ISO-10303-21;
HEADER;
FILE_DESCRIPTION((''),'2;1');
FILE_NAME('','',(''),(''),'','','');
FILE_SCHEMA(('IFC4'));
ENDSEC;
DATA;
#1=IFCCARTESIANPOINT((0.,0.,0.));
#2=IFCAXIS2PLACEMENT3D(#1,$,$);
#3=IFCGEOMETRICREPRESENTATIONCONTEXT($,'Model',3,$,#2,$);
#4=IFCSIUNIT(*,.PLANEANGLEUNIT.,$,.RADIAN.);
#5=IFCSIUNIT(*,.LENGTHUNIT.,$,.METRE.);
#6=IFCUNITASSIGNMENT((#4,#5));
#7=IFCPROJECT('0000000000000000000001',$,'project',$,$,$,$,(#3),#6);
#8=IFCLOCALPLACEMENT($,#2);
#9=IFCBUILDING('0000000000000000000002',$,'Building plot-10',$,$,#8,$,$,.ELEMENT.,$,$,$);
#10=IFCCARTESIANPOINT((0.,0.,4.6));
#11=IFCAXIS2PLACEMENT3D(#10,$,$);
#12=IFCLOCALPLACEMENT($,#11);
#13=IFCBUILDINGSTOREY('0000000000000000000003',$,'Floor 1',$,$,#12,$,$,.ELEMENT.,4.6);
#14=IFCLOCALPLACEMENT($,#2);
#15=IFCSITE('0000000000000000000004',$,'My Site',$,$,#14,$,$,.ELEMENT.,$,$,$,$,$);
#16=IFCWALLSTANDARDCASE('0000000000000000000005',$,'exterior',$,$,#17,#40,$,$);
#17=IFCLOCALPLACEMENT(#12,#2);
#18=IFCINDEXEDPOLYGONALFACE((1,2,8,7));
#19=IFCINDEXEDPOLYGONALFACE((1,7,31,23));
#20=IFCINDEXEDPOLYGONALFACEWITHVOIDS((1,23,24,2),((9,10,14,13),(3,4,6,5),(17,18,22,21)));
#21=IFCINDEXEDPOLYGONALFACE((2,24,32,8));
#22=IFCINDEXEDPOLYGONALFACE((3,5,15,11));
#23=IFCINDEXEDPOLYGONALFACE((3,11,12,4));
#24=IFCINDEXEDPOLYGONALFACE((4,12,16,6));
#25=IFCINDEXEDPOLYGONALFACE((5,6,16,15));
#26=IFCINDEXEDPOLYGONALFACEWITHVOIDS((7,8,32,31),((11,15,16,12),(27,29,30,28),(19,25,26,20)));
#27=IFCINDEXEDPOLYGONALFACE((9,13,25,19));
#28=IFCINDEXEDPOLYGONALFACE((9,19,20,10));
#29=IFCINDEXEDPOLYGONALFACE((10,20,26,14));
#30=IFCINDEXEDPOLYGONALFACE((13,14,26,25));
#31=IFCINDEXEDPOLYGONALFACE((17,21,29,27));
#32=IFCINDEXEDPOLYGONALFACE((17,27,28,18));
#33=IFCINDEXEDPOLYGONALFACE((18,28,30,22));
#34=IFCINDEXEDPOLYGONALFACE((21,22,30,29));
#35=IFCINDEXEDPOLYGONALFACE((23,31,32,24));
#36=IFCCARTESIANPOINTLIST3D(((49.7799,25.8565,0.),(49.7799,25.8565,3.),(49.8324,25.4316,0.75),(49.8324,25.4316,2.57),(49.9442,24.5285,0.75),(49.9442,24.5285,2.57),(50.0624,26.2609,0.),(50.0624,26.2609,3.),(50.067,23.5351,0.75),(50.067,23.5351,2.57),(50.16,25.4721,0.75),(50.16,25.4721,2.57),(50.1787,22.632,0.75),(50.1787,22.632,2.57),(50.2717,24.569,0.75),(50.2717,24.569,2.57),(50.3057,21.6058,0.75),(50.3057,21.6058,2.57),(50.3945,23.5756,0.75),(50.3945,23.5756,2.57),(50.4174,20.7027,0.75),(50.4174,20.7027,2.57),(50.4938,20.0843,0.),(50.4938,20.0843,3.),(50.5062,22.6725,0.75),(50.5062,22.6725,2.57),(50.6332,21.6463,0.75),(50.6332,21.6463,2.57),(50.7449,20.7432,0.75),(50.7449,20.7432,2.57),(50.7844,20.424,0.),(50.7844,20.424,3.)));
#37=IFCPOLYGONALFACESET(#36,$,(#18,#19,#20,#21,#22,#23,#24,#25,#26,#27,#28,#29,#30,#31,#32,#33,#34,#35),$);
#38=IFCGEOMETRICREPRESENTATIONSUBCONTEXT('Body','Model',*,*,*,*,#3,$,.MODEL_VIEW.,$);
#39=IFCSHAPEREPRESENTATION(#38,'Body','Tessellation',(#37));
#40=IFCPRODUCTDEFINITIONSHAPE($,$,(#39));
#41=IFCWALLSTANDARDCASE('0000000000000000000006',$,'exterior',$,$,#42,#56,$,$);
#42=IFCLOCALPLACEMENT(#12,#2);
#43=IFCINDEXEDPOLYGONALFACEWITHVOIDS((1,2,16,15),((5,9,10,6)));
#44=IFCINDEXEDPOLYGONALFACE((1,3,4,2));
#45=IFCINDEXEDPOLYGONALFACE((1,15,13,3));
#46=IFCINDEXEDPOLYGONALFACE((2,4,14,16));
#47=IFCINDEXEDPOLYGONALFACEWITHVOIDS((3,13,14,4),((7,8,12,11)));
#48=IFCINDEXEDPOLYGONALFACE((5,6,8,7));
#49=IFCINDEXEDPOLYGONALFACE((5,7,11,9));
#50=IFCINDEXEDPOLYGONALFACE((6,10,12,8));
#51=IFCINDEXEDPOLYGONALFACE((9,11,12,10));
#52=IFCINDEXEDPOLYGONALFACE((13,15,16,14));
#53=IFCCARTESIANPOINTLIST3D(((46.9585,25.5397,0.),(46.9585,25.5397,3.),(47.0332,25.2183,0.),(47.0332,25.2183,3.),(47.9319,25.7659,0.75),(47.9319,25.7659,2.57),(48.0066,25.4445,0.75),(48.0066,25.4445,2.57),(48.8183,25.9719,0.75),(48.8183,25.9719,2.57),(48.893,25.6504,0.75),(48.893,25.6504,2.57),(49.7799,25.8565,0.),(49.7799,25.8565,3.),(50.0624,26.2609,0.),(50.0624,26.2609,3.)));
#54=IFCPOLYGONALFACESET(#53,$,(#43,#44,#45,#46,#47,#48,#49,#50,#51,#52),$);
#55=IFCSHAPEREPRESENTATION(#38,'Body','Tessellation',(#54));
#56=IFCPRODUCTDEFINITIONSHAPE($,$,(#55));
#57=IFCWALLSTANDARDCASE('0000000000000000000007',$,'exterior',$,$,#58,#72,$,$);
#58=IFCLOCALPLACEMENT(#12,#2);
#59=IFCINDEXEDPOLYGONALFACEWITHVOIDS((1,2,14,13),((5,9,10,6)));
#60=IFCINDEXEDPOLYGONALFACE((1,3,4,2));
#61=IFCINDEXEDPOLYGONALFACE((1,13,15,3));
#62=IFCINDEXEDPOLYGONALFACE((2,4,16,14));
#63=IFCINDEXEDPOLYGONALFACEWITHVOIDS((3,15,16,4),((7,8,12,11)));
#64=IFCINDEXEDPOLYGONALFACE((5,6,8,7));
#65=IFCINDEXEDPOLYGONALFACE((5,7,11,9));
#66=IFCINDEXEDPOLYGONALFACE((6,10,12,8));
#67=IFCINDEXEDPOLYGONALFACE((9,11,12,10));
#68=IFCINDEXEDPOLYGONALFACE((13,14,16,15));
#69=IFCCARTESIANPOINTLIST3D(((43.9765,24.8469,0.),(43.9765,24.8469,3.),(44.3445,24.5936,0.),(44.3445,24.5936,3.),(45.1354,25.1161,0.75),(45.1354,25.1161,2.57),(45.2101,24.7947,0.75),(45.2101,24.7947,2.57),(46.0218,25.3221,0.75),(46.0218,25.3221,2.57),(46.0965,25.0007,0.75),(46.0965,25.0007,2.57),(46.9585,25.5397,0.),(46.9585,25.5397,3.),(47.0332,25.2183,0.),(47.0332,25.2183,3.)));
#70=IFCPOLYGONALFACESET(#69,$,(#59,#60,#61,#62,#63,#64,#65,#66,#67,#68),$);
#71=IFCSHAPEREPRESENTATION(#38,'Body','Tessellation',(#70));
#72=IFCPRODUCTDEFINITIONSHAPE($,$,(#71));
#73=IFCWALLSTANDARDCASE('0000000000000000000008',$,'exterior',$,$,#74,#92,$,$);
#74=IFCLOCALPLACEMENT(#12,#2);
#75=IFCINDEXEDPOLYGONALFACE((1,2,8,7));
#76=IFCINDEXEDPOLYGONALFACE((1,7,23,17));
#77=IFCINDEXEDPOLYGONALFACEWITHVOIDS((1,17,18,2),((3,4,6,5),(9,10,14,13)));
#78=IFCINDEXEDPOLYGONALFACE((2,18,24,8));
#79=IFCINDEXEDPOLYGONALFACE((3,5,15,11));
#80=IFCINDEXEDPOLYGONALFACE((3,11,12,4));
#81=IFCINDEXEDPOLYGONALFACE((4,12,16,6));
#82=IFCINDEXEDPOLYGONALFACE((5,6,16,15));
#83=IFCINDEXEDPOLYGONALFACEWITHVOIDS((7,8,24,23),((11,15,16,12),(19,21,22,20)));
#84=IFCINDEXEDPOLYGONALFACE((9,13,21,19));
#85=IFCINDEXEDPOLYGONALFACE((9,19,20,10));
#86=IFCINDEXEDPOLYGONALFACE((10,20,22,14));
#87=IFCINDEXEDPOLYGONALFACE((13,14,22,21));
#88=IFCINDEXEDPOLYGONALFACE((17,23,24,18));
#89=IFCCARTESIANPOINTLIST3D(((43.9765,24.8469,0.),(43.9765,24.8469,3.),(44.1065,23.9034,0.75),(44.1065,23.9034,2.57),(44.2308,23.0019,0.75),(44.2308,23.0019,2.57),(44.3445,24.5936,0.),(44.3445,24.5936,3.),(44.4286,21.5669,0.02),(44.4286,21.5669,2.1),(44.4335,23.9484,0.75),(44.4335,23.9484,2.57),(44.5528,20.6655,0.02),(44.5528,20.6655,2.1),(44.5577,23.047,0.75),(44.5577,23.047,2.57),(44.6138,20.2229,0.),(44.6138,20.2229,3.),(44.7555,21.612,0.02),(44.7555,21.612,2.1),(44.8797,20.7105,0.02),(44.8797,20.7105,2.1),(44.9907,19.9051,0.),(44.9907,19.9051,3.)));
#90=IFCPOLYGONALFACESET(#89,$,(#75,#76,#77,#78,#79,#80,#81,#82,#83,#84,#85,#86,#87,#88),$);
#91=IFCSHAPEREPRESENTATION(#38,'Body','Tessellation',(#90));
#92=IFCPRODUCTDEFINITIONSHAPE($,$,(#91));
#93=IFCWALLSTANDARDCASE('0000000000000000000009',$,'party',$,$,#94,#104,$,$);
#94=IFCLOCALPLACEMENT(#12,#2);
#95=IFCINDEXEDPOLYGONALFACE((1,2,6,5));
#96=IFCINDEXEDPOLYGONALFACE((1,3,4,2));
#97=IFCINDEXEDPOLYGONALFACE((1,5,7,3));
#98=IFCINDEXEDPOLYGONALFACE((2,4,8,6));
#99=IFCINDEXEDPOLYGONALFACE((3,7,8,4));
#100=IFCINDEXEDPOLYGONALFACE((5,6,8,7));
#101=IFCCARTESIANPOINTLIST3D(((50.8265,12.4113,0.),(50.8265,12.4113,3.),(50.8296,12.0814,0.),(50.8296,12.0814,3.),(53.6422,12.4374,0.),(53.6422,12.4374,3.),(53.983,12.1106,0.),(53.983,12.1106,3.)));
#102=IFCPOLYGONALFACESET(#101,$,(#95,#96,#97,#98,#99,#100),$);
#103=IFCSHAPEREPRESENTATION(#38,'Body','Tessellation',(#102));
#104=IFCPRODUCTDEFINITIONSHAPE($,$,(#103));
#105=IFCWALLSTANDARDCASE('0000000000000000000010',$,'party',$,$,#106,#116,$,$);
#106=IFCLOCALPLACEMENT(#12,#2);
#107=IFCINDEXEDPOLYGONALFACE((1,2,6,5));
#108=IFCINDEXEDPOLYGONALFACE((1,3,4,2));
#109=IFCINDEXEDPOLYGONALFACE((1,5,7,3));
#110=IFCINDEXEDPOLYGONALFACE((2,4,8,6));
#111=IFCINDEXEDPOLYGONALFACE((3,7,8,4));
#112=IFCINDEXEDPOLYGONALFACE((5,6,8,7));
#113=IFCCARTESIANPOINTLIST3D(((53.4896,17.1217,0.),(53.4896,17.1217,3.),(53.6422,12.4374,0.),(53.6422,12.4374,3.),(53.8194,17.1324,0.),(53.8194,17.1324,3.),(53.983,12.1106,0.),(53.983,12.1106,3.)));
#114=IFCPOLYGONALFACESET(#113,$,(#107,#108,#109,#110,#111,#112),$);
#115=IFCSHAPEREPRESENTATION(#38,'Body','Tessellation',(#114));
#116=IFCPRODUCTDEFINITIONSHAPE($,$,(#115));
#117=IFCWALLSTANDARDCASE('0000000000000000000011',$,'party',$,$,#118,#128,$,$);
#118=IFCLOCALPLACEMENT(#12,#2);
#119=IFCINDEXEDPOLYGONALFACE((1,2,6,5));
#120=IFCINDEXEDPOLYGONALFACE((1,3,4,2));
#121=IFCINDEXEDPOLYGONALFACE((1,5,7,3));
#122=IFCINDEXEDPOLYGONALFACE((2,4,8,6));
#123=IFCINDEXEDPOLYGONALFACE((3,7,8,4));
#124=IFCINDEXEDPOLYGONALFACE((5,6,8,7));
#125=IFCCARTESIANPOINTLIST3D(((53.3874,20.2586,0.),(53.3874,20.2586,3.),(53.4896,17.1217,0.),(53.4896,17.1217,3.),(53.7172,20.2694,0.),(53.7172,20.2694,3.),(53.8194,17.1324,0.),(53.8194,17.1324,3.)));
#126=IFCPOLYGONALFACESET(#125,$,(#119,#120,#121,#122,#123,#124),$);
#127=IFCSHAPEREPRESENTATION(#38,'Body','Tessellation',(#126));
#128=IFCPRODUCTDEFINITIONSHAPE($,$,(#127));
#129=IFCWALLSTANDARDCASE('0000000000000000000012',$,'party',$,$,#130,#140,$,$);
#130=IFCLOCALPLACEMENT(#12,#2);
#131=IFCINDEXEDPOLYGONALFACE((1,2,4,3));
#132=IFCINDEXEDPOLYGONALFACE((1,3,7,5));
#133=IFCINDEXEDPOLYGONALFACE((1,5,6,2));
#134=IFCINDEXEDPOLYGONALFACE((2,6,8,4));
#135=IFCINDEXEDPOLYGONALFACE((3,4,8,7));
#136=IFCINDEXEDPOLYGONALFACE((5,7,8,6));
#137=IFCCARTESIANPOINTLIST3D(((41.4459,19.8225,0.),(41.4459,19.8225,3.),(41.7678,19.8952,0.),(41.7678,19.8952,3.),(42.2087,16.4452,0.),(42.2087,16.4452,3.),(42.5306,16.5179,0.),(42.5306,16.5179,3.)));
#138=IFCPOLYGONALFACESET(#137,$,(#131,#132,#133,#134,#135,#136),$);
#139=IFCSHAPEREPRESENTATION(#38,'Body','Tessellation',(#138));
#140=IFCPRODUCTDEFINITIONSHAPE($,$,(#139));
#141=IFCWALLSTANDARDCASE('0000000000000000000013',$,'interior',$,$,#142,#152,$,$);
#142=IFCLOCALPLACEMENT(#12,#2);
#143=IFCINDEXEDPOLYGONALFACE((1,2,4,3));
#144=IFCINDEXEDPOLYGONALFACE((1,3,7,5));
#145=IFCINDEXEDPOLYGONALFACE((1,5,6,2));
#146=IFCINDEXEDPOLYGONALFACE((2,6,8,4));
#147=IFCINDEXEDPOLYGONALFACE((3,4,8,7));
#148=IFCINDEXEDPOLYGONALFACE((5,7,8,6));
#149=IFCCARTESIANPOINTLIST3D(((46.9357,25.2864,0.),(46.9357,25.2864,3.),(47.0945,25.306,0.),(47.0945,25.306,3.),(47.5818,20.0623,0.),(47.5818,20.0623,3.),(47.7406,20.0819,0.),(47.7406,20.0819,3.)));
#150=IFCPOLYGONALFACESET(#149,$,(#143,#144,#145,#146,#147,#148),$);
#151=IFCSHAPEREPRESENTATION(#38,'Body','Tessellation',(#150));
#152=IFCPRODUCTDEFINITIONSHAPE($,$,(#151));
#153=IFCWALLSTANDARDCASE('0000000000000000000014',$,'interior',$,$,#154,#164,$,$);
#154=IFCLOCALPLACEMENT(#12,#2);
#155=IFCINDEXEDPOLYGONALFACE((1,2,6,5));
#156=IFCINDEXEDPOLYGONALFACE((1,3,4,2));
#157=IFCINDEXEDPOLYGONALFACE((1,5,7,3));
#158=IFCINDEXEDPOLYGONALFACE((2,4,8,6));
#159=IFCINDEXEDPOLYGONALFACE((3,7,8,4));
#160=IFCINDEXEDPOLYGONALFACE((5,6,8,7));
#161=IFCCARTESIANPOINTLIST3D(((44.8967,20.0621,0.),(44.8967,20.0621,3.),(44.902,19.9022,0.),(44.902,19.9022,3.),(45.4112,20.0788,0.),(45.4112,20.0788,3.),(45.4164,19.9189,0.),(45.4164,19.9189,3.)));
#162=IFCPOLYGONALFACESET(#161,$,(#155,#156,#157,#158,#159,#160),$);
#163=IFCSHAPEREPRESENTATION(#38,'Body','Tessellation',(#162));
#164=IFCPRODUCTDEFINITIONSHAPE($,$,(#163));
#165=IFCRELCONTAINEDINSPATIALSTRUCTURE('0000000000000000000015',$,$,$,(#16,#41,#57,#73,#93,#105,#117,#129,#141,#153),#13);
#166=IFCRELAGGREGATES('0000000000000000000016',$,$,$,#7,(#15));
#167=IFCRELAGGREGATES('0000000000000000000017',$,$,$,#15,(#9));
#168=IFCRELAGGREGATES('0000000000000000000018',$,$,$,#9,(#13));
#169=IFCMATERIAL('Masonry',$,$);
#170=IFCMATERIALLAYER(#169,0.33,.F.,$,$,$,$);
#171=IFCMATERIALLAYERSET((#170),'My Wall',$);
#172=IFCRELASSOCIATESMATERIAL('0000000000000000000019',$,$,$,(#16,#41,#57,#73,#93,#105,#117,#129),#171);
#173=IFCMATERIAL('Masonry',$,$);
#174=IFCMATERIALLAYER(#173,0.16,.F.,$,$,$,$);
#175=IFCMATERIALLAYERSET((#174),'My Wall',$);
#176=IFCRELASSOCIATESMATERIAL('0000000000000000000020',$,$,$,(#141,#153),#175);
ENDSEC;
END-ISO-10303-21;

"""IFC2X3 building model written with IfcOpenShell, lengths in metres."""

from ifc_helpers import new_model, si_unit, frame, origin, place, context, subcontext, project, spatial, polyline, outline, extrude, material, layer, layer_set, layer_usage, element, save


model = new_model("IFC2X3")

# Units and contexts
model_context = context("Model", 3, world=origin())
body_context = subcontext(model_context, "Body", "Model", "MODEL_VIEW")
ifc_project = project(units=[si_unit("PLANEANGLEUNIT", "RADIAN"), si_unit("LENGTHUNIT", "METRE")], contexts=[model_context])

# Site, building, storey
site_placement = place(None, origin())
site = spatial("IfcSite", under=ifc_project, at=site_placement, Name="My Site", CompositionType="ELEMENT")
building_placement = place(None, origin())
building = spatial("IfcBuilding", under=site, at=building_placement, Name="Building plot-10", CompositionType="ELEMENT")
storey_placement = place(None, frame((0.0, 0.0, 4.6)))
storey = spatial("IfcBuildingStorey", under=building, at=storey_placement, Name="Floor 1", CompositionType="ELEMENT", Elevation=4.6)

# Wall, openings
ifc_material_1 = material(Name="Masonry")
ifc_layer_1 = layer(ifc_material_1, 0.33, ventilated=False)
ifc_layer_set_1 = layer_set([ifc_layer_1], Name="My Wall")
ifc_layer_usage_1 = layer_usage(ifc_layer_set_1, "AXIS2", "NEGATIVE", 0.08)
wall_1_placement = place(storey_placement, origin())
wall_1 = element("IfcWallStandardCase", 1, at=wall_1_placement, inside=storey, material=ifc_layer_usage_1, Name="exterior", context=body_context, shape_type="SweptSolid", body=[
    extrude(outline(polyline([(50.4938, 20.0843), (50.7844, 20.424), (50.0624, 26.2609), (49.7799, 25.8565), (50.4938, 20.0843)])), origin(), (0.0, 0.0, 1.0), 3.0),
])
opening_1_placement = place(storey_placement, frame((0.0, 0.0, 0.75)))
element("IfcOpeningElement", 2, at=opening_1_placement, cuts=wall_1, ObjectType="Opening", context=body_context, shape_type="SweptSolid", body=[
    extrude(outline(polyline([(50.7449, 20.7432), (50.6332, 21.6463), (50.3057, 21.6058), (50.4174, 20.7027), (50.7449, 20.7432)])), origin(), (0.0, 0.0, 1.0), 1.82),
])
opening_2_placement = place(storey_placement, frame((0.0, 0.0, 0.75)))
element("IfcOpeningElement", 3, at=opening_2_placement, cuts=wall_1, ObjectType="Opening", context=body_context, shape_type="SweptSolid", body=[
    extrude(outline(polyline([(50.5062, 22.6725), (50.3945, 23.5756), (50.067, 23.5351), (50.1787, 22.632), (50.5062, 22.6725)])), origin(), (0.0, 0.0, 1.0), 1.82),
])
opening_3_placement = place(storey_placement, frame((0.0, 0.0, 0.75)))
element("IfcOpeningElement", 4, at=opening_3_placement, cuts=wall_1, ObjectType="Opening", context=body_context, shape_type="SweptSolid", body=[
    extrude(outline(polyline([(50.2717, 24.569), (50.16, 25.4721), (49.8324, 25.4316), (49.9442, 24.5285), (50.2717, 24.569)])), origin(), (0.0, 0.0, 1.0), 1.82),
])

# Walls, openings
wall_2_placement = place(storey_placement, origin())
wall_2 = element("IfcWallStandardCase", 5, at=wall_2_placement, inside=storey, material=ifc_layer_usage_1, Name="exterior", context=body_context, shape_type="SweptSolid", body=[
    extrude(outline(polyline([(49.7799, 25.8565), (50.0624, 26.2609), (46.9585, 25.5397), (47.0332, 25.2183), (49.7799, 25.8565)])), origin(), (0.0, 0.0, 1.0), 3.0),
])
opening_4_placement = place(storey_placement, frame((0.0, 0.0, 0.75)))
element("IfcOpeningElement", 6, at=opening_4_placement, cuts=wall_2, ObjectType="Opening", context=body_context, shape_type="SweptSolid", body=[
    extrude(outline(polyline([(48.8183, 25.9719), (47.9319, 25.7659), (48.0066, 25.4445), (48.893, 25.6504), (48.8183, 25.9719)])), origin(), (0.0, 0.0, 1.0), 1.82),
])
wall_3_placement = place(storey_placement, origin())
wall_3 = element("IfcWallStandardCase", 7, at=wall_3_placement, inside=storey, material=ifc_layer_usage_1, Name="exterior", context=body_context, shape_type="SweptSolid", body=[
    extrude(outline(polyline([(47.0332, 25.2183), (46.9585, 25.5397), (43.9765, 24.8469), (44.3445, 24.5936), (47.0332, 25.2183)])), origin(), (0.0, 0.0, 1.0), 3.0),
])
opening_5_placement = place(storey_placement, frame((0.0, 0.0, 0.75)))
element("IfcOpeningElement", 8, at=opening_5_placement, cuts=wall_3, ObjectType="Opening", context=body_context, shape_type="SweptSolid", body=[
    extrude(outline(polyline([(46.0218, 25.3221), (45.1354, 25.1161), (45.2101, 24.7947), (46.0965, 25.0007), (46.0218, 25.3221)])), origin(), (0.0, 0.0, 1.0), 1.82),
])

# Wall, openings
wall_4_placement = place(storey_placement, origin())
wall_4 = element("IfcWallStandardCase", 9, at=wall_4_placement, inside=storey, material=ifc_layer_usage_1, Name="exterior", context=body_context, shape_type="SweptSolid", body=[
    extrude(outline(polyline([(44.3445, 24.5936), (43.9765, 24.8469), (44.6138, 20.2229), (44.9907, 19.9051), (44.3445, 24.5936)])), origin(), (0.0, 0.0, 1.0), 3.0),
])
opening_6_placement = place(storey_placement, frame((0.0, 0.0, 0.75)))
element("IfcOpeningElement", 10, at=opening_6_placement, cuts=wall_4, ObjectType="Opening", context=body_context, shape_type="SweptSolid", body=[
    extrude(outline(polyline([(44.1065, 23.9034), (44.2308, 23.0019), (44.5577, 23.047), (44.4335, 23.9484), (44.1065, 23.9034)])), origin(), (0.0, 0.0, 1.0), 1.82),
])
opening_7_placement = place(storey_placement, frame((0.0, 0.0, 0.02)))
element("IfcOpeningElement", 11, at=opening_7_placement, cuts=wall_4, ObjectType="Opening", context=body_context, shape_type="SweptSolid", body=[
    extrude(outline(polyline([(44.4286, 21.5669), (44.5528, 20.6655), (44.8797, 20.7105), (44.7555, 21.612), (44.4286, 21.5669)])), origin(), (0.0, 0.0, 1.0), 2.08),
])

# Walls
wall_5_placement = place(storey_placement, origin())
element("IfcWallStandardCase", 12, at=wall_5_placement, inside=storey, material=ifc_layer_usage_1, Name="party", context=body_context, shape_type="SweptSolid", body=[
    extrude(outline(polyline([(50.8265, 12.4113), (50.8296, 12.0814), (53.983, 12.1106), (53.6422, 12.4374), (50.8265, 12.4113)])), origin(), (0.0, 0.0, 1.0), 3.0),
])
wall_6_placement = place(storey_placement, origin())
element("IfcWallStandardCase", 13, at=wall_6_placement, inside=storey, material=ifc_layer_usage_1, Name="party", context=body_context, shape_type="SweptSolid", body=[
    extrude(outline(polyline([(53.6422, 12.4374), (53.983, 12.1106), (53.8194, 17.1324), (53.4896, 17.1217), (53.6422, 12.4374)])), origin(), (0.0, 0.0, 1.0), 3.0),
])
wall_7_placement = place(storey_placement, origin())
element("IfcWallStandardCase", 14, at=wall_7_placement, inside=storey, material=ifc_layer_usage_1, Name="party", context=body_context, shape_type="SweptSolid", body=[
    extrude(outline(polyline([(53.4896, 17.1217), (53.8194, 17.1324), (53.7172, 20.2694), (53.3874, 20.2586), (53.4896, 17.1217)])), origin(), (0.0, 0.0, 1.0), 3.0),
])
wall_8_placement = place(storey_placement, origin())
element("IfcWallStandardCase", 15, at=wall_8_placement, inside=storey, material=ifc_layer_usage_1, Name="party", context=body_context, shape_type="SweptSolid", body=[
    extrude(outline(polyline([(41.7678, 19.8952), (41.4459, 19.8225), (42.2087, 16.4452), (42.5306, 16.5179), (41.7678, 19.8952)])), origin(), (0.0, 0.0, 1.0), 3.0),
])
ifc_material_2 = material(Name="Masonry")
ifc_layer_2 = layer(ifc_material_2, 0.16, ventilated=False)
ifc_layer_set_2 = layer_set([ifc_layer_2], Name="My Wall")
ifc_layer_usage_2 = layer_usage(ifc_layer_set_2, "AXIS2", "NEGATIVE", 0.08)
wall_9_placement = place(storey_placement, origin())
element("IfcWallStandardCase", 16, at=wall_9_placement, inside=storey, material=ifc_layer_usage_2, Name="interior", context=body_context, shape_type="SweptSolid", body=[
    extrude(outline(polyline([(47.5818, 20.0623), (47.7406, 20.0819), (47.0945, 25.306), (46.9357, 25.2864), (47.5818, 20.0623)])), origin(), (0.0, 0.0, 1.0), 3.0),
])
wall_10_placement = place(storey_placement, origin())
element("IfcWallStandardCase", 17, at=wall_10_placement, inside=storey, material=ifc_layer_usage_2, Name="interior", context=body_context, shape_type="SweptSolid", body=[
    extrude(outline(polyline([(44.8967, 20.0621), (44.902, 19.9022), (45.4164, 19.9189), (45.4112, 20.0788), (44.8967, 20.0621)])), origin(), (0.0, 0.0, 1.0), 3.0),
])

save(model, "model.ifc")
